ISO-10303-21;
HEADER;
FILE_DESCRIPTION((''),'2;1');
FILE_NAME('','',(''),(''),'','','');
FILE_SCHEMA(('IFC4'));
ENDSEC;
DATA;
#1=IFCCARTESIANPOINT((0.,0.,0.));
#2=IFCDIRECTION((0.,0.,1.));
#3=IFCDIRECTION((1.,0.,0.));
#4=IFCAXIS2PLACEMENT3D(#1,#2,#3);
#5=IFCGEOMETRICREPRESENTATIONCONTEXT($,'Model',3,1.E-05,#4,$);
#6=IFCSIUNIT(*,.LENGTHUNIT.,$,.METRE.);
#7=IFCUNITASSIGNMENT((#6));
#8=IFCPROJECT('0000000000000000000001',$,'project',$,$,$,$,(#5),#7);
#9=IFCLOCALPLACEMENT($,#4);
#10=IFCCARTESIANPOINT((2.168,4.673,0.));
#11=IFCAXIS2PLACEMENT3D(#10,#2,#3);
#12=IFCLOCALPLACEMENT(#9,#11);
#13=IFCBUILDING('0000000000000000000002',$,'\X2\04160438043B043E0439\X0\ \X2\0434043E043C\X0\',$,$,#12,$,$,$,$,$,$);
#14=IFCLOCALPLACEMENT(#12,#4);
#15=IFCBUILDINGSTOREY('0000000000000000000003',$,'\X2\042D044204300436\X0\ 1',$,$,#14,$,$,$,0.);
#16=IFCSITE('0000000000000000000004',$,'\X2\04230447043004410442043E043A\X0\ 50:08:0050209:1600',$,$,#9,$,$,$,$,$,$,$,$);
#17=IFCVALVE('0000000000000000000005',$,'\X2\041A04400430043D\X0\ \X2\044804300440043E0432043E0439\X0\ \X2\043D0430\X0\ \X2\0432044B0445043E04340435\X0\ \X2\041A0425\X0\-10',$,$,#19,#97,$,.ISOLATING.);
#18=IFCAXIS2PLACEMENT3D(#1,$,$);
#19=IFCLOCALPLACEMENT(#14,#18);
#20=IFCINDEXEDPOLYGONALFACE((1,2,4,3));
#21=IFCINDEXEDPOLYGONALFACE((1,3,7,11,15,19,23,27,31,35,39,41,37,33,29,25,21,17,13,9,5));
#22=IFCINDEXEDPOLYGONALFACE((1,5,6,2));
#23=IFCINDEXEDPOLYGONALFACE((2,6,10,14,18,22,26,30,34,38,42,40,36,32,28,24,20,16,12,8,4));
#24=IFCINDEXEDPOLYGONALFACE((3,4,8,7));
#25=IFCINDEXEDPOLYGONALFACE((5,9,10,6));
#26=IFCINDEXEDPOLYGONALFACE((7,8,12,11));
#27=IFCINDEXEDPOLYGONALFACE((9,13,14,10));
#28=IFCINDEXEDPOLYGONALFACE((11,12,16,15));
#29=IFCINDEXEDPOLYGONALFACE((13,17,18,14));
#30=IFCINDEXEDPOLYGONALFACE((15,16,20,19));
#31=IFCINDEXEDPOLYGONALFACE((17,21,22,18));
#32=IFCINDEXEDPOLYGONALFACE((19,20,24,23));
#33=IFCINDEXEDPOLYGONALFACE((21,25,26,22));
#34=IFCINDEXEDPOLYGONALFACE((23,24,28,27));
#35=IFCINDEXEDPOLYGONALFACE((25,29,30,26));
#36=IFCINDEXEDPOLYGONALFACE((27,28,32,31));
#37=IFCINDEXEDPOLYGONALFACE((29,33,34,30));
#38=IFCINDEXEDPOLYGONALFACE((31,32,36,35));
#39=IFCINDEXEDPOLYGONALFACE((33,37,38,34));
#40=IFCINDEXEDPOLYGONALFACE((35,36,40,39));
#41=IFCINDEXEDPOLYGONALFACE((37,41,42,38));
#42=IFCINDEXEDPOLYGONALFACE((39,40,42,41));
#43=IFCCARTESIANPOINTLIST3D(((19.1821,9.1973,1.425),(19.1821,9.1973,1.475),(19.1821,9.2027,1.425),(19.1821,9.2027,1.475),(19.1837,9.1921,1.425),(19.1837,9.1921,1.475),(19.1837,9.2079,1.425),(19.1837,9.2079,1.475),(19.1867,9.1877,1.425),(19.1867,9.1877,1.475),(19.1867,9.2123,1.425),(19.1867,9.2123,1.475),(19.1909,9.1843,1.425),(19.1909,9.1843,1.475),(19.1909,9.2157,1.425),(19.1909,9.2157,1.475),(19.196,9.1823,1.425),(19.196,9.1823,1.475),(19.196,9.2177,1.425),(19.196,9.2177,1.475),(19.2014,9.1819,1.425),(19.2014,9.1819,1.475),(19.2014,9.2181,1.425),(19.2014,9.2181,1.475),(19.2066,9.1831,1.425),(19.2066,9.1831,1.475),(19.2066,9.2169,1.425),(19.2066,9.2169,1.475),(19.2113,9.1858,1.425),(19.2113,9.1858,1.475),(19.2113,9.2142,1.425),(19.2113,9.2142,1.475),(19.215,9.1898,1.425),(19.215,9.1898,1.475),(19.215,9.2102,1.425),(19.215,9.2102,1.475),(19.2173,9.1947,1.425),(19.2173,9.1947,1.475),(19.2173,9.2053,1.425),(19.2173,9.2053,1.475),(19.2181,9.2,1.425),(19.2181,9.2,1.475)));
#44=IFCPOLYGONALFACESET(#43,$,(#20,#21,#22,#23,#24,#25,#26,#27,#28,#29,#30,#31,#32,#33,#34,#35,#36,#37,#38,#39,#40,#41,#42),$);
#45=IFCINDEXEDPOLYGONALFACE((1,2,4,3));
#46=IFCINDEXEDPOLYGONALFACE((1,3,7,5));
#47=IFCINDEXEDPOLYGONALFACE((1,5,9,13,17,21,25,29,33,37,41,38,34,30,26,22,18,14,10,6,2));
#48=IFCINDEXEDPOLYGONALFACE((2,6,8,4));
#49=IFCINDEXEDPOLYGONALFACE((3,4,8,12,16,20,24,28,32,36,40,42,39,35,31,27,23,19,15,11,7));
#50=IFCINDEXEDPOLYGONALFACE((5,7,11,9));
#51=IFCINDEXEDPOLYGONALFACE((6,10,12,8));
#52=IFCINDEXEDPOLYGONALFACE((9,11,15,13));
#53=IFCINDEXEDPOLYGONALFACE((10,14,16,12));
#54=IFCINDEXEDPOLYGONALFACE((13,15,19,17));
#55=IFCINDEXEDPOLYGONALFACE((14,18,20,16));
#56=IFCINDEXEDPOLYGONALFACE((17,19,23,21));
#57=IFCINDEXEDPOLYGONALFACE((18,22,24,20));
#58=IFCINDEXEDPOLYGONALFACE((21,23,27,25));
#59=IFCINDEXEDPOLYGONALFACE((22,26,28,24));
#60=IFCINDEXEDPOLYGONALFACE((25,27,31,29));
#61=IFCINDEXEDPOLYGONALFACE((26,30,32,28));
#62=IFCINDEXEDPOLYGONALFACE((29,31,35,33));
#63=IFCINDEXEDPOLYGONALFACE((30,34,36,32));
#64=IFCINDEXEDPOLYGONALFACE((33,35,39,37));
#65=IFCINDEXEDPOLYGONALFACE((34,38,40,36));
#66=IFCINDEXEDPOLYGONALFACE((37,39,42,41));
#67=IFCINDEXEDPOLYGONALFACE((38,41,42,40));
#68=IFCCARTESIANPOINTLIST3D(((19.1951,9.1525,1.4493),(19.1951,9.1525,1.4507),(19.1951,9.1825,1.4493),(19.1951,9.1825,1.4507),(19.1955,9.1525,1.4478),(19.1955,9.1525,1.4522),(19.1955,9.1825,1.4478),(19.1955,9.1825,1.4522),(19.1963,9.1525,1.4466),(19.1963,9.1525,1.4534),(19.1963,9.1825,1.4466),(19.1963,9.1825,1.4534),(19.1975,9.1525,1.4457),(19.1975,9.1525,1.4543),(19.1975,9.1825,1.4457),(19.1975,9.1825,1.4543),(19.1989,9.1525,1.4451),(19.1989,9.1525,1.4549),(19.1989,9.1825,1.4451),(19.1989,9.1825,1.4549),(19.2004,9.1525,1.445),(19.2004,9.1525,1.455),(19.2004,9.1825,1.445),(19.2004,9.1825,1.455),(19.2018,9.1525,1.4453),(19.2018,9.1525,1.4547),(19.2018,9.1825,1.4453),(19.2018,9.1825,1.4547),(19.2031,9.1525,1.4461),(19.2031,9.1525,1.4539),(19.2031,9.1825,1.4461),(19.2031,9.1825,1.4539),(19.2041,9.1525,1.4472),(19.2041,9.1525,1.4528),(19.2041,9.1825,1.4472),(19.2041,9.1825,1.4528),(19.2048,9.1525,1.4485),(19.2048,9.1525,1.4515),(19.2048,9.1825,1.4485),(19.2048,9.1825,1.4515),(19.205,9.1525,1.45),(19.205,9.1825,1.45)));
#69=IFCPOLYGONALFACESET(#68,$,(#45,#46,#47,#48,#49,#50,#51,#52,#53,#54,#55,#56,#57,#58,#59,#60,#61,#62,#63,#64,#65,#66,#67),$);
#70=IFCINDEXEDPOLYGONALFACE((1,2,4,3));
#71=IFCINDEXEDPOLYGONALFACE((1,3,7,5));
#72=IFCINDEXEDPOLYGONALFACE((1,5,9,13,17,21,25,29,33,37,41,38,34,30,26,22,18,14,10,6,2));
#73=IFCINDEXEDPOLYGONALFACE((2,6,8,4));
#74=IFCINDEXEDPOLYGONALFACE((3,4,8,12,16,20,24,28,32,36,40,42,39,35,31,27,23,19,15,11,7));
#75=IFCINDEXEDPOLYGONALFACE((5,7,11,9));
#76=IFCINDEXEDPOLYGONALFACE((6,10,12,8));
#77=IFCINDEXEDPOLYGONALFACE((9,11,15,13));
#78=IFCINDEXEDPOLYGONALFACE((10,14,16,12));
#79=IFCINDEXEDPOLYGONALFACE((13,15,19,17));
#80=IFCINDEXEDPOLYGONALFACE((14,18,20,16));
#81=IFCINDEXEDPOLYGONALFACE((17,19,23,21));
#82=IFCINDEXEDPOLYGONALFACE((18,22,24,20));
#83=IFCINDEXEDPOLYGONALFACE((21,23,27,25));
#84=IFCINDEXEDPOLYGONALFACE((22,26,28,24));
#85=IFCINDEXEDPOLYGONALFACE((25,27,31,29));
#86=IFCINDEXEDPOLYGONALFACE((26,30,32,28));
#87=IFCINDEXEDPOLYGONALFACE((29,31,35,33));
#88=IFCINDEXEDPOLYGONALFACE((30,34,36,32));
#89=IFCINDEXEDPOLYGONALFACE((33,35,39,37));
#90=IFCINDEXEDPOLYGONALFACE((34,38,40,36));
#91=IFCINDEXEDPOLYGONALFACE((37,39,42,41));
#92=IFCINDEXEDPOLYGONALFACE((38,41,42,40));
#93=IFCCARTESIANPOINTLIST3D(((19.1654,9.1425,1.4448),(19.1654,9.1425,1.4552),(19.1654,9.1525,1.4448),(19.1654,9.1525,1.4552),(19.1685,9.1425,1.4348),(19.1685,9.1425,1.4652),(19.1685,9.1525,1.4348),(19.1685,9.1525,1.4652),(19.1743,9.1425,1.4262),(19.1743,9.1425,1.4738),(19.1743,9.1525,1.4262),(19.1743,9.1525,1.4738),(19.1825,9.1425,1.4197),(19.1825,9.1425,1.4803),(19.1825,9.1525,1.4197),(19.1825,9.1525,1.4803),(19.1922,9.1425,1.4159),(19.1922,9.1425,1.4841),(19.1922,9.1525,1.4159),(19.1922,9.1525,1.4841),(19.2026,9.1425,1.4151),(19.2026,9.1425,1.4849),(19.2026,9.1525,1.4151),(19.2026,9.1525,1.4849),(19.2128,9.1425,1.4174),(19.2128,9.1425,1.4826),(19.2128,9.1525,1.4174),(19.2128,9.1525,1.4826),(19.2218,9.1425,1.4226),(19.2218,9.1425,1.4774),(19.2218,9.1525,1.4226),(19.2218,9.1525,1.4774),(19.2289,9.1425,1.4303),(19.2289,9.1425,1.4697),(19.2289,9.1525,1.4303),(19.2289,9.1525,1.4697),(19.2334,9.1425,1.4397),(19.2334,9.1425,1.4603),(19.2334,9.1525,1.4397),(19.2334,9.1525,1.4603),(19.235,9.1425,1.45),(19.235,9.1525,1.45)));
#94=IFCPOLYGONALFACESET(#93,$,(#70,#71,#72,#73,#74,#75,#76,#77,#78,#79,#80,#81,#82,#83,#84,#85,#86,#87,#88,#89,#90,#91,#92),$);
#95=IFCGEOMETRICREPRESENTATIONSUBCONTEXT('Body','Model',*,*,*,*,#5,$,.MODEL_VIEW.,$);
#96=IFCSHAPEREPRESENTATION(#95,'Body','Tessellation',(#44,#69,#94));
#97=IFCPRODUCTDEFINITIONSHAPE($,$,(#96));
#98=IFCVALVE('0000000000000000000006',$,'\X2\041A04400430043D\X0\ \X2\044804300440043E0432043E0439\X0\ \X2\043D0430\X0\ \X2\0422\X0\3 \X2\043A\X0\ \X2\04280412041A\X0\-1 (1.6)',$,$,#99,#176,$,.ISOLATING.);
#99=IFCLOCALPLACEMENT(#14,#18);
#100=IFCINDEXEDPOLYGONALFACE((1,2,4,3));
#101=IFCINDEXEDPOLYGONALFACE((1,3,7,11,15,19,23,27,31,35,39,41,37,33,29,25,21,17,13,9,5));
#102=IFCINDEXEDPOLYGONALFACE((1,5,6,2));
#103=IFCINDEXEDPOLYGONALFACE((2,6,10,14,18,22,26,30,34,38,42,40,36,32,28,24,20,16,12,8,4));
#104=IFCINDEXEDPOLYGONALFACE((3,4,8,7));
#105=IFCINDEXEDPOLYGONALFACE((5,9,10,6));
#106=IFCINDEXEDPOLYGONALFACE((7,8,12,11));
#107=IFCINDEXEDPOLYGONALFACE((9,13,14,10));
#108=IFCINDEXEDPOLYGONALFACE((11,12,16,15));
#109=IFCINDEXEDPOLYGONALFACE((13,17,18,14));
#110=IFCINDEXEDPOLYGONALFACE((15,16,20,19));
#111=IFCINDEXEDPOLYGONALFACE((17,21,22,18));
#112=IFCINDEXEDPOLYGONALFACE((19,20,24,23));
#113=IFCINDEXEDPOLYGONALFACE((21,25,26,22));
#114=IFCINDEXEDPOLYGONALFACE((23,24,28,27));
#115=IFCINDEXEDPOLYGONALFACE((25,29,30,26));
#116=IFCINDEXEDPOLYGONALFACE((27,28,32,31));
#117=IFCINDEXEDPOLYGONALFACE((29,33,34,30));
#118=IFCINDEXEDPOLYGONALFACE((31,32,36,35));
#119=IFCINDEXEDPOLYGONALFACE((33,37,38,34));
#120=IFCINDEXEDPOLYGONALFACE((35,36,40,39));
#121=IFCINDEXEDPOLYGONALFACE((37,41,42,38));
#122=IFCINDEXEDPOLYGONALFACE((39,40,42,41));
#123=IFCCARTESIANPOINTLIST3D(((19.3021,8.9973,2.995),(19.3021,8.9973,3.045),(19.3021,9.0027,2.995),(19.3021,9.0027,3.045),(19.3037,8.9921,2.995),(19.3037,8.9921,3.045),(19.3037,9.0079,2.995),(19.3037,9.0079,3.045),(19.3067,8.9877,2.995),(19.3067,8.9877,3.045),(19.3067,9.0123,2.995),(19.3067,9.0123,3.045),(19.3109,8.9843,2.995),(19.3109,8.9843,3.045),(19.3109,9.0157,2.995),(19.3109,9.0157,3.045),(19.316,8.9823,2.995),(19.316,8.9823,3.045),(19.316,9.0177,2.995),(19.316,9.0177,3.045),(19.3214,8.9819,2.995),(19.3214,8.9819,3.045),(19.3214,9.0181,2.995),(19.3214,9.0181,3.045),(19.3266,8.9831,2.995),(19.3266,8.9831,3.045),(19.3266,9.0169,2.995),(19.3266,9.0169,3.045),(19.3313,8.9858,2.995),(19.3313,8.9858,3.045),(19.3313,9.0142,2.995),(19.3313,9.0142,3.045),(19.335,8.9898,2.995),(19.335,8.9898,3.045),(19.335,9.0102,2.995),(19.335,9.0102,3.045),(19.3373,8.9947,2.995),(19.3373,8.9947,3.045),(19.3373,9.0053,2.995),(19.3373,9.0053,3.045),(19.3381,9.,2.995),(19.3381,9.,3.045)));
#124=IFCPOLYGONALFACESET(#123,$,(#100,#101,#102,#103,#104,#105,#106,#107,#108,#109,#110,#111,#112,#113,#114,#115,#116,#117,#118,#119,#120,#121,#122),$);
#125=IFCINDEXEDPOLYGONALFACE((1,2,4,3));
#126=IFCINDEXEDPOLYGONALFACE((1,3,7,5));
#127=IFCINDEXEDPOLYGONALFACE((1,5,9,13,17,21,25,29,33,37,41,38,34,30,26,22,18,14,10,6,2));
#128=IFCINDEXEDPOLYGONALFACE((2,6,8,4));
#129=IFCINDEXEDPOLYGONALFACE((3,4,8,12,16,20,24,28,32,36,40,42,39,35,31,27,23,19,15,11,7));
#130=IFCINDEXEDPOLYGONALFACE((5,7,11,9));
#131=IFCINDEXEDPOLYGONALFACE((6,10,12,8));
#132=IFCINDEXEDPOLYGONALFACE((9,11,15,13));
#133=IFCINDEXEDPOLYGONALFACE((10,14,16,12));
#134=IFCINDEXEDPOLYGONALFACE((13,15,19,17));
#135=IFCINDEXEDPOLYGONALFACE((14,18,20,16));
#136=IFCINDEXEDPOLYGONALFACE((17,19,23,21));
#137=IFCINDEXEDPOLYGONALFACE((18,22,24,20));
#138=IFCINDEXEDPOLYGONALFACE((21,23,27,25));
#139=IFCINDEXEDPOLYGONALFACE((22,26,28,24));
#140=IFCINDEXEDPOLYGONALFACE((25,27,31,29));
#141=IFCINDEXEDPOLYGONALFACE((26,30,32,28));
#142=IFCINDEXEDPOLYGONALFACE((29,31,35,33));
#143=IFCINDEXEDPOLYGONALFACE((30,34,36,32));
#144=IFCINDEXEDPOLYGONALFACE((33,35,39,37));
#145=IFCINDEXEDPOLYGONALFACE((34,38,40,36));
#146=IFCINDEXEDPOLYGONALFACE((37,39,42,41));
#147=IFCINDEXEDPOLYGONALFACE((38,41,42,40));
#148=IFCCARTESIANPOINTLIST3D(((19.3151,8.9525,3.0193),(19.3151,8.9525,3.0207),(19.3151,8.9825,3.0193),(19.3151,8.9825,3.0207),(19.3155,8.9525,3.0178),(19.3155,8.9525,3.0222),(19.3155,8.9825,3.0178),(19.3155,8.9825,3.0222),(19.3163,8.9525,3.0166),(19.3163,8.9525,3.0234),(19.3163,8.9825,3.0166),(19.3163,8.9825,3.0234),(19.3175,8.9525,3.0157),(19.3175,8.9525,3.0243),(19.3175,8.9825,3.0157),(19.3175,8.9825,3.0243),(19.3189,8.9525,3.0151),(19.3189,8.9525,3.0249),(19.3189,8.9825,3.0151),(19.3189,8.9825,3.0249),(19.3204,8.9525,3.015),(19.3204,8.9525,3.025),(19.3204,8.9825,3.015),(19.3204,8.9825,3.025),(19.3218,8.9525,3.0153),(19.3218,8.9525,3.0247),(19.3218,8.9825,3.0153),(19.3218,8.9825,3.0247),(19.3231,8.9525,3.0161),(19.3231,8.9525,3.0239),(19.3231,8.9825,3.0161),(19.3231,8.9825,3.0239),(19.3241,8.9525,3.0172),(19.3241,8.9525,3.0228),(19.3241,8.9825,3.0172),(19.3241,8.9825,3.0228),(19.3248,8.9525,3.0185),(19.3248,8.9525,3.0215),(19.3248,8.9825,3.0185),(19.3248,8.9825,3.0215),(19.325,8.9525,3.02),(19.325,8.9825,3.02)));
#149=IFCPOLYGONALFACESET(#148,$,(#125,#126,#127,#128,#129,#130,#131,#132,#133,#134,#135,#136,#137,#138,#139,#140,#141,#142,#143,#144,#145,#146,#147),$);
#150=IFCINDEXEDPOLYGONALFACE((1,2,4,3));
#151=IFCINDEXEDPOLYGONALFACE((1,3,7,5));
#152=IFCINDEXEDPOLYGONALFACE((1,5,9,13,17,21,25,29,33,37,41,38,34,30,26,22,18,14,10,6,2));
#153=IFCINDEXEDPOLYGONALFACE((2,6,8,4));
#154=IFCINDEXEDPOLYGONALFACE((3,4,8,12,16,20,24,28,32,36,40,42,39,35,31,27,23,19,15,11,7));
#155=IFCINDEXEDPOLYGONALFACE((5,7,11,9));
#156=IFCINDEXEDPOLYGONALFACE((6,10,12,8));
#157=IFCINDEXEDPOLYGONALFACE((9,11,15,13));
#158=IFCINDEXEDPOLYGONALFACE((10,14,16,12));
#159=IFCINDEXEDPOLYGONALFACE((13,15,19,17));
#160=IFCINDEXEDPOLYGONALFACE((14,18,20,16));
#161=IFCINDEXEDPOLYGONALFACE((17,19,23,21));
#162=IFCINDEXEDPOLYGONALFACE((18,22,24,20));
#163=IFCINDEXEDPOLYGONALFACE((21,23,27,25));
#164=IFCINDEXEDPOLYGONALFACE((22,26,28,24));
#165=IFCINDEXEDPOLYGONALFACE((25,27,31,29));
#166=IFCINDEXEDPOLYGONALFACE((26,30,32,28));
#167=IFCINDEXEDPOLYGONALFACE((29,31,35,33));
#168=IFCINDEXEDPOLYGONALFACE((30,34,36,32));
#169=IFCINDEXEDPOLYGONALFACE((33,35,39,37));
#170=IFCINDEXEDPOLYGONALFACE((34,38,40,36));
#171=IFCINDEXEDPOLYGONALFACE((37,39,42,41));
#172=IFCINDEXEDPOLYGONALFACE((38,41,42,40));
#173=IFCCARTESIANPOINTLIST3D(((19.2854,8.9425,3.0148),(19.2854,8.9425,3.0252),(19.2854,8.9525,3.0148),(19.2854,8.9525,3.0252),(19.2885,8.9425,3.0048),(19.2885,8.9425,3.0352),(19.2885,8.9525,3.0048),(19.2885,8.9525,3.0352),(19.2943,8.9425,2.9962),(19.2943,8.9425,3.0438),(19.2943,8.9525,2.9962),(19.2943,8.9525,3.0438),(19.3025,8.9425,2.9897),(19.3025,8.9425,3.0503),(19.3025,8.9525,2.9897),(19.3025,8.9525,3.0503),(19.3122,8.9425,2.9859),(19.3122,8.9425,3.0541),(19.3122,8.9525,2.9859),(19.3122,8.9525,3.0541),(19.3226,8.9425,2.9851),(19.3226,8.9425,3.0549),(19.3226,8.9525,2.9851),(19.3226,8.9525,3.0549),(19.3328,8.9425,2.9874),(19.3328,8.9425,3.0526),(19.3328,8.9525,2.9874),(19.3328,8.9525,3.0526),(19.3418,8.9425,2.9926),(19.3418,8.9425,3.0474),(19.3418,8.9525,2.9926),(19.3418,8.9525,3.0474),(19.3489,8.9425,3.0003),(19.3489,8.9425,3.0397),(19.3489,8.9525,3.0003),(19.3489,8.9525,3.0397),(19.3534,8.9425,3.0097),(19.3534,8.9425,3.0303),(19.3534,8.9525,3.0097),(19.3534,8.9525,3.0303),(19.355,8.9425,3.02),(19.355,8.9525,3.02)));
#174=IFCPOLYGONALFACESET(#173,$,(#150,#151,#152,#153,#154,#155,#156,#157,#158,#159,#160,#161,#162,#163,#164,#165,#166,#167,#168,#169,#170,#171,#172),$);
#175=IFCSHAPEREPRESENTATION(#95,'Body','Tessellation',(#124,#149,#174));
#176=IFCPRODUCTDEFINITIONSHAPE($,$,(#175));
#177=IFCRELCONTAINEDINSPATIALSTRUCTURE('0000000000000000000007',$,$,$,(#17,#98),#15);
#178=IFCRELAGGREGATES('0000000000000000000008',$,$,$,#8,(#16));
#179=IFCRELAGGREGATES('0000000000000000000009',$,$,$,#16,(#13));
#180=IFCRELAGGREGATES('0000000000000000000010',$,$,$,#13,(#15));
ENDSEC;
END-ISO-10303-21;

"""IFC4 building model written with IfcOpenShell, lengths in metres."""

from ifc_helpers import new_model, si_unit, frame, origin_with_axes, origin_2d, place, context, subcontext, project, spatial, circle, extrude, element, save


model = new_model("IFC4")

# Units and contexts
model_context = context("Model", 3, precision=1e-05, world=origin_with_axes())
body_context = subcontext(model_context, "Body", "Model", "MODEL_VIEW")
ifc_project = project(units=[si_unit("LENGTHUNIT", "METRE")], contexts=[model_context])

# Site, building, storey
site_placement = place(None, origin_with_axes())
site = spatial("IfcSite", under=ifc_project, at=site_placement, Name="Участок 50:08:0050209:1600")
building_placement = place(site_placement, frame((2.168, 4.673, 0.0), z_axis=(0.0, 0.0, 1.0), x_axis=(1.0, 0.0, 0.0)))
building = spatial("IfcBuilding", under=site, at=building_placement, Name="Жилой дом")
storey_placement = place(building_placement, origin_with_axes())
storey = spatial("IfcBuildingStorey", under=building, at=storey_placement, Name="Этаж 1", Elevation=0.0)

# Valves
valve_1_placement = place(storey_placement, origin_with_axes())
element("IfcValve", 1, at=valve_1_placement, inside=storey, Name="Кран шаровой на выходе КХ-10", PredefinedType="ISOLATING", context=body_context, shape_type="SweptSolid", body=[
    extrude(circle(Radius=0.0181, at=origin_2d()), frame((19.2, 9.2, 1.425), z_axis=(0.0, 0.0, 1.0), x_axis=(1.0, 0.0, 0.0)), (0.0, 0.0, 1.0), 0.05),
    extrude(circle(Radius=0.005, at=origin_2d()), frame((19.2, 9.1825, 1.45), z_axis=(0.0, -1.0, 0.0), x_axis=(1.0, 0.0, 0.0)), (0.0, 0.0, 1.0), 0.03),
    extrude(circle(Radius=0.035, at=origin_2d()), frame((19.2, 9.1525, 1.45), z_axis=(0.0, -1.0, 0.0), x_axis=(1.0, 0.0, 0.0)), (0.0, 0.0, 1.0), 0.01),
])
valve_2_placement = place(storey_placement, origin_with_axes())
element("IfcValve", 2, at=valve_2_placement, inside=storey, Name="Кран шаровой на Т3 к ШВК-1 (1.6)", PredefinedType="ISOLATING", context=body_context, shape_type="SweptSolid", body=[
    extrude(circle(Radius=0.0181, at=origin_2d()), frame((19.32, 9.0, 2.995), z_axis=(0.0, 0.0, 1.0), x_axis=(1.0, 0.0, 0.0)), (0.0, 0.0, 1.0), 0.05),
    extrude(circle(Radius=0.005, at=origin_2d()), frame((19.32, 8.9825, 3.02), z_axis=(0.0, -1.0, 0.0), x_axis=(1.0, 0.0, 0.0)), (0.0, 0.0, 1.0), 0.03),
    extrude(circle(Radius=0.035, at=origin_2d()), frame((19.32, 8.9525, 3.02), z_axis=(0.0, -1.0, 0.0), x_axis=(1.0, 0.0, 0.0)), (0.0, 0.0, 1.0), 0.01),
])

save(model, "model.ifc")
